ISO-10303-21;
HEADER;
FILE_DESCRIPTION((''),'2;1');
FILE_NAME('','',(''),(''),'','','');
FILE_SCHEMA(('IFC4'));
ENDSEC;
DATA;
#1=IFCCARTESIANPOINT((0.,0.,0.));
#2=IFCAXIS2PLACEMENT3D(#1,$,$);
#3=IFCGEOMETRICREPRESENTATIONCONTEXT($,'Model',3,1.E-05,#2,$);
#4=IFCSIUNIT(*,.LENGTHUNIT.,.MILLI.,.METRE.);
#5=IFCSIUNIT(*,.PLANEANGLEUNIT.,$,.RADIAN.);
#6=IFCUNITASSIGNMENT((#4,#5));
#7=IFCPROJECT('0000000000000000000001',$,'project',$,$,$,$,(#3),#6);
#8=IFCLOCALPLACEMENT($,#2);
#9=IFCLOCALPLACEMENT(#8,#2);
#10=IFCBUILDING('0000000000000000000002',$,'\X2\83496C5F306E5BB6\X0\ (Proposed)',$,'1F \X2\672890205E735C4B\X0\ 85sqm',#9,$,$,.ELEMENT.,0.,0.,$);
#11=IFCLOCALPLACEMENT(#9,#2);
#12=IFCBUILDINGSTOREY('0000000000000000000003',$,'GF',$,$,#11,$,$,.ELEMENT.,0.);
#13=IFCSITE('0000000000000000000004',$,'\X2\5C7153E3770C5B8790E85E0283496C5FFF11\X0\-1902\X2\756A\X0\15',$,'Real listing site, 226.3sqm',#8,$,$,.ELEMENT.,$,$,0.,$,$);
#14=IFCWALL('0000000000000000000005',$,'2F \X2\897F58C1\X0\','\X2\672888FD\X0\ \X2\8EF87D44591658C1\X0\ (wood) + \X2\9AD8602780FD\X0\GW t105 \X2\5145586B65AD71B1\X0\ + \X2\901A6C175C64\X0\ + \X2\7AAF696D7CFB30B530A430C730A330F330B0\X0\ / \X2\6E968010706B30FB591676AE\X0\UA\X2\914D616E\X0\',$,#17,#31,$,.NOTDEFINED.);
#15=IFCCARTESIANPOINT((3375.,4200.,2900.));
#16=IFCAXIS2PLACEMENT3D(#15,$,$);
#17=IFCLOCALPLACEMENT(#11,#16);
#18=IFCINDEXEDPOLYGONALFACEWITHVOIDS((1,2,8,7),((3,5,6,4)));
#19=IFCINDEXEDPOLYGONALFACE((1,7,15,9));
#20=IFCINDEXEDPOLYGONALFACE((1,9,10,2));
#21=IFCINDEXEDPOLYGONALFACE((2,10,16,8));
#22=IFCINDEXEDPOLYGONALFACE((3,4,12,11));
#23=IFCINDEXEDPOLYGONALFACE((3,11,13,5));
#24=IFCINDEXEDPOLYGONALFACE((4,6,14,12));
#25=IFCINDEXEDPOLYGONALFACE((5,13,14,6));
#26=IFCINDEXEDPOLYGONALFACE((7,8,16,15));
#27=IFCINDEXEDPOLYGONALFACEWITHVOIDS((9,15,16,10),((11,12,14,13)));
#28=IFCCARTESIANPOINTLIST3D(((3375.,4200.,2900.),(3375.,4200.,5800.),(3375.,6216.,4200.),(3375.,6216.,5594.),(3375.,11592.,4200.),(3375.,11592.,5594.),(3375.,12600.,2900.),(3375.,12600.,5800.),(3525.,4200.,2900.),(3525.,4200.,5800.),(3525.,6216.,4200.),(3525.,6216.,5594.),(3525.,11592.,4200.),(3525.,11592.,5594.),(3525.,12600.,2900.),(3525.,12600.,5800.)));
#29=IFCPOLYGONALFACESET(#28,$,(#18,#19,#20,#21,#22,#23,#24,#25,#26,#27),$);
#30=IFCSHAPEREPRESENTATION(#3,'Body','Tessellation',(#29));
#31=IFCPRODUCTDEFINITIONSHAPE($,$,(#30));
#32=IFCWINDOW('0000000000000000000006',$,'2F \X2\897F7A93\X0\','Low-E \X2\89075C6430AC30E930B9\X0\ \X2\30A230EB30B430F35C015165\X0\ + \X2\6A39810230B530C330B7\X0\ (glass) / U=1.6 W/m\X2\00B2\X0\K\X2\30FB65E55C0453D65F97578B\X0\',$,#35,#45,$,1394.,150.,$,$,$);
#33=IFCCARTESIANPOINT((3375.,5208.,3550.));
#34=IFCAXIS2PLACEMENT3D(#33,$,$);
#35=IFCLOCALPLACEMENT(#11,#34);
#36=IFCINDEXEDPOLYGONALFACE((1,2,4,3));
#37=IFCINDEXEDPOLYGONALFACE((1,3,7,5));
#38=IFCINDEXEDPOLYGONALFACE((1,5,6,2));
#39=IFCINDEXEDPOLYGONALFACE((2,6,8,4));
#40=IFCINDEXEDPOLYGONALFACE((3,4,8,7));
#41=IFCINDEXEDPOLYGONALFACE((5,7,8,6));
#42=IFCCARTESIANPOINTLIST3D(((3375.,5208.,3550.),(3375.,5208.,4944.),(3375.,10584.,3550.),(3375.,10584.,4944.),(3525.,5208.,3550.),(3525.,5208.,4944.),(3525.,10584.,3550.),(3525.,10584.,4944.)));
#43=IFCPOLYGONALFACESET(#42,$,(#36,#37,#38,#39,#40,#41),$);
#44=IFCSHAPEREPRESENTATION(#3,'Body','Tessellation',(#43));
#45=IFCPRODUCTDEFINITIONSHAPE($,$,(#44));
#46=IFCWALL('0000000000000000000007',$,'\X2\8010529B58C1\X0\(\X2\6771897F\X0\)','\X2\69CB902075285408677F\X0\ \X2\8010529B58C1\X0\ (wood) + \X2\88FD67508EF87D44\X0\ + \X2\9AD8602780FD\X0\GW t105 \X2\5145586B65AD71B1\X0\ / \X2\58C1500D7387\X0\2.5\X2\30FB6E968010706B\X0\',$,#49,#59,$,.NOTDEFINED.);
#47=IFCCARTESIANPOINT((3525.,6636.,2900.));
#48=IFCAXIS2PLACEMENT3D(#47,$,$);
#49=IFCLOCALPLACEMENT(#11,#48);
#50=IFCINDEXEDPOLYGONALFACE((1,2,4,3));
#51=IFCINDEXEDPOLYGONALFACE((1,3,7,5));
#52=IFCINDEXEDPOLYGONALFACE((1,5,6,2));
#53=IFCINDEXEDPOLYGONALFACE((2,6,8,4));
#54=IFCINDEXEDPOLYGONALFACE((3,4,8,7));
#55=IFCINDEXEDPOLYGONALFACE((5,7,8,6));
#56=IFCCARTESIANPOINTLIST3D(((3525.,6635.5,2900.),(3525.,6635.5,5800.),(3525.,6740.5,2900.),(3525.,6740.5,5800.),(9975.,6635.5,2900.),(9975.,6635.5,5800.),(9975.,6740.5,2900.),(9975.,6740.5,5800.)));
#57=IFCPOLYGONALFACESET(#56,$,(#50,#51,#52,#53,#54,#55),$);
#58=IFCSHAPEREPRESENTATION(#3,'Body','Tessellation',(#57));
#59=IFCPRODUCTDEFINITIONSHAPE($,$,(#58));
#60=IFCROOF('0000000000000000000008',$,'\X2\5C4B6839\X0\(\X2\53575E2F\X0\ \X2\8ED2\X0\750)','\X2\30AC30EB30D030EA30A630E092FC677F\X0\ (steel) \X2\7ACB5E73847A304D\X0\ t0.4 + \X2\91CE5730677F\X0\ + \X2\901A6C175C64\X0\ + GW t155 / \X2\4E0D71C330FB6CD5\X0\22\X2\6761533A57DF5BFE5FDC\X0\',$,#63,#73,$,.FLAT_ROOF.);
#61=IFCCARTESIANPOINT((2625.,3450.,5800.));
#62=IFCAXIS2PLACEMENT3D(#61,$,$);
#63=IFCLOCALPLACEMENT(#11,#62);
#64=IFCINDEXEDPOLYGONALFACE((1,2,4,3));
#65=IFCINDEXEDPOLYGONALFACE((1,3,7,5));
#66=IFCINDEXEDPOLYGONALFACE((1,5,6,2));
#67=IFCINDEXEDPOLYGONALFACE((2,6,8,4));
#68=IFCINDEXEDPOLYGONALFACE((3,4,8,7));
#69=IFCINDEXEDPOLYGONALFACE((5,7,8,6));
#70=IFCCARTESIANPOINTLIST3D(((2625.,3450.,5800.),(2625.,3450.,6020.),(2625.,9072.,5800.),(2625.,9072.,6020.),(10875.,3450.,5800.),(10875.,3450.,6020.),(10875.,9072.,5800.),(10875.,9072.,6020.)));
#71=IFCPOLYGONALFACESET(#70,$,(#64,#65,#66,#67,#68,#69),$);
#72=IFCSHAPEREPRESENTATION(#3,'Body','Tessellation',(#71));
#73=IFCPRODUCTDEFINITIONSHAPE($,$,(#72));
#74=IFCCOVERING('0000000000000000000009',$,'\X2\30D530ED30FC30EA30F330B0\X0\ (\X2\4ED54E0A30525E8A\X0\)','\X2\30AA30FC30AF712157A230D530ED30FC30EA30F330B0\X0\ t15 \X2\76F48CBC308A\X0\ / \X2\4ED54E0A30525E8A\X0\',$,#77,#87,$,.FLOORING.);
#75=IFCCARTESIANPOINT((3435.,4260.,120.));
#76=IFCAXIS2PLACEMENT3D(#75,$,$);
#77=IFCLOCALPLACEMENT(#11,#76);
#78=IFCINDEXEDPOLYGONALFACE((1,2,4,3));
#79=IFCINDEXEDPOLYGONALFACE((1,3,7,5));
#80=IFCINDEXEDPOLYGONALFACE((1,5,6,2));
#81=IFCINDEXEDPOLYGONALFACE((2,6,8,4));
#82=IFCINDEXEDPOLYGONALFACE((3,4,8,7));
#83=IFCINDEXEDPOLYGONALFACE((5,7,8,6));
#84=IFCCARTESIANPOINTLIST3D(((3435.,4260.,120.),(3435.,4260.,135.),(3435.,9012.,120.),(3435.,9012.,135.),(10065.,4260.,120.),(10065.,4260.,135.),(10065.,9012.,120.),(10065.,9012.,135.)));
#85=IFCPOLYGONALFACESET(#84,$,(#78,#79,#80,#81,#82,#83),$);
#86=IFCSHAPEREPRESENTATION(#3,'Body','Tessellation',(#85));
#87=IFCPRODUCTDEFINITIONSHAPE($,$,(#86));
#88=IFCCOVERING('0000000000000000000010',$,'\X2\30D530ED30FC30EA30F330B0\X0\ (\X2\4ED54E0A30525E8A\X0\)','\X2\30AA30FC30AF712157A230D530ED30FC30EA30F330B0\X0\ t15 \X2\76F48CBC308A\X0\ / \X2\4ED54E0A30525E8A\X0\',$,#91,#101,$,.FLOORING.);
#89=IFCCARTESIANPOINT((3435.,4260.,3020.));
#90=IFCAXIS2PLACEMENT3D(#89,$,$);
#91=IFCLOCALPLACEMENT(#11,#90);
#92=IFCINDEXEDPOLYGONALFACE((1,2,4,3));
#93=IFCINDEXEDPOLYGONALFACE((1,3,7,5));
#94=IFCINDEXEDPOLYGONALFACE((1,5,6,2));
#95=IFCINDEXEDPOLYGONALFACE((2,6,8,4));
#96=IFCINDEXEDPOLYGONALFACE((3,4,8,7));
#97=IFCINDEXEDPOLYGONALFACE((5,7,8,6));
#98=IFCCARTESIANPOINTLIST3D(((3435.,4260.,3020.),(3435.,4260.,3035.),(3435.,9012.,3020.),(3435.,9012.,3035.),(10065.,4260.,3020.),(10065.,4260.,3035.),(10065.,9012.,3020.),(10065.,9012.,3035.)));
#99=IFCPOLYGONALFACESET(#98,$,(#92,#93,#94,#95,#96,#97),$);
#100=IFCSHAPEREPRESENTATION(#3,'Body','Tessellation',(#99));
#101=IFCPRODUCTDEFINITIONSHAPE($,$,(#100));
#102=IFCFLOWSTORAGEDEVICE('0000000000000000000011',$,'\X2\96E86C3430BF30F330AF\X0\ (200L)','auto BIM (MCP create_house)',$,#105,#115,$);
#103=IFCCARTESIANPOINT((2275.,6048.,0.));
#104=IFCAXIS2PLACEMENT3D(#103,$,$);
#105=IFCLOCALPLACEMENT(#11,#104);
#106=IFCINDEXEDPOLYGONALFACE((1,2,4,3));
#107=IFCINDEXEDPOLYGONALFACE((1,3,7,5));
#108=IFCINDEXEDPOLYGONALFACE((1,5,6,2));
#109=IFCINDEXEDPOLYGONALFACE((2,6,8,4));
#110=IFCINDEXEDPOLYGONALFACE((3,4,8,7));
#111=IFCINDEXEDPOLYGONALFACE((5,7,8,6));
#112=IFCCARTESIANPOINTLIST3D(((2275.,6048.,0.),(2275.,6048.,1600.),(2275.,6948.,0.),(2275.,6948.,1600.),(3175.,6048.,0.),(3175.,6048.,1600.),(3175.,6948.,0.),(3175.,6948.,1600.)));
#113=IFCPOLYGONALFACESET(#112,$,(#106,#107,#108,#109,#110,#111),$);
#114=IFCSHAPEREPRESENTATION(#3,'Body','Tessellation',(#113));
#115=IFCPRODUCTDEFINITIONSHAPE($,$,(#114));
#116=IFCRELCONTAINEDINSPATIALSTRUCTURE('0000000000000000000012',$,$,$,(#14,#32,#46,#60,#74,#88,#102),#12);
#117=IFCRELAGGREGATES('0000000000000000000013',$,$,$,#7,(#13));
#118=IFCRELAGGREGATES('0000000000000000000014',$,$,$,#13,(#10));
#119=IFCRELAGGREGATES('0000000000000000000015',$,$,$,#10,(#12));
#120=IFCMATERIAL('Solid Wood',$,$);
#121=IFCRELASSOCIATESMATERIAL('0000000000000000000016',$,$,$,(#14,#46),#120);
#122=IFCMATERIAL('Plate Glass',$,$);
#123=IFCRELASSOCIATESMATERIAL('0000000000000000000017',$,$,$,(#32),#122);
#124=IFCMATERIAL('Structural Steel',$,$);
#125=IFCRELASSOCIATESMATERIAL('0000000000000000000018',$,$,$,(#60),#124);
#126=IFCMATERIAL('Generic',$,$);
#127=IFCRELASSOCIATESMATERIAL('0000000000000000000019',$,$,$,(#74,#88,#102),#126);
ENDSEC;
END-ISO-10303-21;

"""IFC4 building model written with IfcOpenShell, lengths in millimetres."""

from ifc_helpers import new_model, si_unit, frame, frame_2d, origin, place, context, project, spatial, rectangle, extrude, material, element, fill, save


model = new_model("IFC4")

# Units and contexts
model_context = context("Model", 3, precision=1e-05, world=origin())
ifc_project = project(units=[si_unit("LENGTHUNIT", "METRE", prefix="MILLI"), si_unit("PLANEANGLEUNIT", "RADIAN")], contexts=[model_context])

# Site, building, storey
site_placement = place(None, origin())
site = spatial("IfcSite", under=ifc_project, at=site_placement, Name="山口県宇部市草江１-1902番15", ObjectType="Real listing site, 226.3sqm", CompositionType="ELEMENT", RefElevation=0.0)
building_placement = place(site_placement, origin())
building = spatial("IfcBuilding", under=site, at=building_placement, Name="草江の家 (Proposed)", ObjectType="1F 木造平屋 85sqm", CompositionType="ELEMENT", ElevationOfRefHeight=0.0, ElevationOfTerrain=0.0)
storey_placement = place(building_placement, origin())
storey = spatial("IfcBuildingStorey", under=building, at=storey_placement, Name="GF", CompositionType="ELEMENT", Elevation=0.0)

# Shared definitions
ifc_material_1 = material(Name="Solid Wood")
ifc_material_2 = material(Name="Generic")

# Shared definitions
ifc_material_3 = material(Name="Plate Glass")

# Wall, opening, window
wall_1_placement = place(storey_placement, frame((3375.0, 4200.0, 2900.0)))
wall_1 = element("IfcWall", 1, at=wall_1_placement, inside=storey, material=ifc_material_1, Name="2F 西壁", Description="木製 軸組外壁 (wood) + 高性能GW t105 充填断熱 + 通気層 + 窯業系サイディング / 準耐火・外皮UA配慮", PredefinedType="NOTDEFINED", context=model_context, shape_type="SweptSolid", body=[
    extrude(rectangle(XDim=150.0, YDim=8400.0, at=frame_2d((75.0, 4200.0))), frame((3375.0, 4200.0, 2900.0)), (0.0, 0.0, 1.0), 2900.0),
])
opening_1_placement = place(storey_placement, frame((3375.0, 5208.0, 3550.0)))
opening_1 = element("IfcOpeningElement", 2, at=opening_1_placement, cuts=wall_1, PredefinedType="NOTDEFINED", context=model_context, shape_type="SweptSolid", body=[
    extrude(rectangle(XDim=150.0, YDim=5376.0, at=frame_2d((75.0, 2688.0))), frame((3375.0, 5208.0, 3550.0)), (0.0, 0.0, 1.0), 1394.0),
])
window_1_placement = place(storey_placement, frame((3375.0, 5208.0, 3550.0)))
window_1 = element("IfcWindow", 3, at=window_1_placement, inside=storey, material=ifc_material_3, Name="2F 西窓", Description="Low-E 複層ガラス アルゴン封入 + 樹脂サッシ (glass) / U=1.6 W/m²K・日射取得型", OverallHeight=1394.0, OverallWidth=150.0, context=model_context, shape_type="SweptSolid", body=[
    extrude(rectangle(XDim=150.0, YDim=5376.0, at=frame_2d((75.0, 2688.0))), frame((3375.0, 5208.0, 3550.0)), (0.0, 0.0, 1.0), 1394.0),
])
fill(opening_1, window_1)

# Wall
wall_2_placement = place(storey_placement, frame((3525.0, 6636.0, 2900.0)))
element("IfcWall", 4, at=wall_2_placement, inside=storey, material=ifc_material_1, Name="耐力壁(東西)", Description="構造用合板 耐力壁 (wood) + 製材軸組 + 高性能GW t105 充填断熱 / 壁倍率2.5・準耐火", PredefinedType="NOTDEFINED", context=model_context, shape_type="SweptSolid", body=[
    extrude(rectangle(XDim=6450.0, YDim=105.0, at=frame_2d((3225.0, 52.0))), frame((3525.0, 6636.0, 2900.0)), (0.0, 0.0, 1.0), 2900.0),
])

# Roof
ifc_material_4 = material(Name="Structural Steel")
for number, where, name in (
    (5, (2625.0, 3450.0, 5800.0), "屋根(南帯 軒750)"),
):
    element("IfcRoof", number, at=place(storey_placement, frame(where)), inside=storey, material=ifc_material_4, Name=name, Description="ガルバリウム鋼板 (steel) 立平葺き t0.4 + 野地板 + 通気層 + GW t155 / 不燃・法22条区域対応", PredefinedType="FLAT_ROOF", context=model_context, shape_type="SweptSolid", body=[
        extrude(rectangle(XDim=8250.0, YDim=5622.0, at=frame_2d((4125.0, 2811.0))), frame((2625.0, 3450.0, 5800.0)), (0.0, 0.0, 1.0), 220.0),
    ])

# Coverings
covering_1_placement = place(storey_placement, frame((3435.0, 4260.0, 120.0)))
element("IfcCovering", 6, at=covering_1_placement, inside=storey, material=ifc_material_2, Name="フローリング (仕上げ床)", Description="オーク無垢フローリング t15 直貼り / 仕上げ床", PredefinedType="FLOORING", context=model_context, shape_type="SweptSolid", body=[
    extrude(rectangle(XDim=6630.0, YDim=4752.0, at=frame_2d((3315.0, 2376.0))), frame((3435.0, 4260.0, 120.0)), (0.0, 0.0, 1.0), 15.0),
])
covering_2_placement = place(storey_placement, frame((3435.0, 4260.0, 3020.0)))
element("IfcCovering", 7, at=covering_2_placement, inside=storey, material=ifc_material_2, Name="フローリング (仕上げ床)", Description="オーク無垢フローリング t15 直貼り / 仕上げ床", PredefinedType="FLOORING", context=model_context, shape_type="SweptSolid", body=[
    extrude(rectangle(XDim=6630.0, YDim=4752.0, at=frame_2d((3315.0, 2376.0))), frame((3435.0, 4260.0, 3020.0)), (0.0, 0.0, 1.0), 15.0),
])

# Flow storage device
flow_storage_device_placement = place(storey_placement, frame((2275.0, 6048.0, 0.0)))
element("IfcFlowStorageDevice", 8, at=flow_storage_device_placement, inside=storey, material=ifc_material_2, Name="雨水タンク (200L)", Description="auto BIM (MCP create_house)", context=model_context, shape_type="SweptSolid", body=[
    extrude(rectangle(XDim=900.0, YDim=900.0, at=frame_2d((450.0, 450.0))), frame((2275.0, 6048.0, 0.0)), (0.0, 0.0, 1.0), 1600.0),
])

save(model, "model.ifc")
